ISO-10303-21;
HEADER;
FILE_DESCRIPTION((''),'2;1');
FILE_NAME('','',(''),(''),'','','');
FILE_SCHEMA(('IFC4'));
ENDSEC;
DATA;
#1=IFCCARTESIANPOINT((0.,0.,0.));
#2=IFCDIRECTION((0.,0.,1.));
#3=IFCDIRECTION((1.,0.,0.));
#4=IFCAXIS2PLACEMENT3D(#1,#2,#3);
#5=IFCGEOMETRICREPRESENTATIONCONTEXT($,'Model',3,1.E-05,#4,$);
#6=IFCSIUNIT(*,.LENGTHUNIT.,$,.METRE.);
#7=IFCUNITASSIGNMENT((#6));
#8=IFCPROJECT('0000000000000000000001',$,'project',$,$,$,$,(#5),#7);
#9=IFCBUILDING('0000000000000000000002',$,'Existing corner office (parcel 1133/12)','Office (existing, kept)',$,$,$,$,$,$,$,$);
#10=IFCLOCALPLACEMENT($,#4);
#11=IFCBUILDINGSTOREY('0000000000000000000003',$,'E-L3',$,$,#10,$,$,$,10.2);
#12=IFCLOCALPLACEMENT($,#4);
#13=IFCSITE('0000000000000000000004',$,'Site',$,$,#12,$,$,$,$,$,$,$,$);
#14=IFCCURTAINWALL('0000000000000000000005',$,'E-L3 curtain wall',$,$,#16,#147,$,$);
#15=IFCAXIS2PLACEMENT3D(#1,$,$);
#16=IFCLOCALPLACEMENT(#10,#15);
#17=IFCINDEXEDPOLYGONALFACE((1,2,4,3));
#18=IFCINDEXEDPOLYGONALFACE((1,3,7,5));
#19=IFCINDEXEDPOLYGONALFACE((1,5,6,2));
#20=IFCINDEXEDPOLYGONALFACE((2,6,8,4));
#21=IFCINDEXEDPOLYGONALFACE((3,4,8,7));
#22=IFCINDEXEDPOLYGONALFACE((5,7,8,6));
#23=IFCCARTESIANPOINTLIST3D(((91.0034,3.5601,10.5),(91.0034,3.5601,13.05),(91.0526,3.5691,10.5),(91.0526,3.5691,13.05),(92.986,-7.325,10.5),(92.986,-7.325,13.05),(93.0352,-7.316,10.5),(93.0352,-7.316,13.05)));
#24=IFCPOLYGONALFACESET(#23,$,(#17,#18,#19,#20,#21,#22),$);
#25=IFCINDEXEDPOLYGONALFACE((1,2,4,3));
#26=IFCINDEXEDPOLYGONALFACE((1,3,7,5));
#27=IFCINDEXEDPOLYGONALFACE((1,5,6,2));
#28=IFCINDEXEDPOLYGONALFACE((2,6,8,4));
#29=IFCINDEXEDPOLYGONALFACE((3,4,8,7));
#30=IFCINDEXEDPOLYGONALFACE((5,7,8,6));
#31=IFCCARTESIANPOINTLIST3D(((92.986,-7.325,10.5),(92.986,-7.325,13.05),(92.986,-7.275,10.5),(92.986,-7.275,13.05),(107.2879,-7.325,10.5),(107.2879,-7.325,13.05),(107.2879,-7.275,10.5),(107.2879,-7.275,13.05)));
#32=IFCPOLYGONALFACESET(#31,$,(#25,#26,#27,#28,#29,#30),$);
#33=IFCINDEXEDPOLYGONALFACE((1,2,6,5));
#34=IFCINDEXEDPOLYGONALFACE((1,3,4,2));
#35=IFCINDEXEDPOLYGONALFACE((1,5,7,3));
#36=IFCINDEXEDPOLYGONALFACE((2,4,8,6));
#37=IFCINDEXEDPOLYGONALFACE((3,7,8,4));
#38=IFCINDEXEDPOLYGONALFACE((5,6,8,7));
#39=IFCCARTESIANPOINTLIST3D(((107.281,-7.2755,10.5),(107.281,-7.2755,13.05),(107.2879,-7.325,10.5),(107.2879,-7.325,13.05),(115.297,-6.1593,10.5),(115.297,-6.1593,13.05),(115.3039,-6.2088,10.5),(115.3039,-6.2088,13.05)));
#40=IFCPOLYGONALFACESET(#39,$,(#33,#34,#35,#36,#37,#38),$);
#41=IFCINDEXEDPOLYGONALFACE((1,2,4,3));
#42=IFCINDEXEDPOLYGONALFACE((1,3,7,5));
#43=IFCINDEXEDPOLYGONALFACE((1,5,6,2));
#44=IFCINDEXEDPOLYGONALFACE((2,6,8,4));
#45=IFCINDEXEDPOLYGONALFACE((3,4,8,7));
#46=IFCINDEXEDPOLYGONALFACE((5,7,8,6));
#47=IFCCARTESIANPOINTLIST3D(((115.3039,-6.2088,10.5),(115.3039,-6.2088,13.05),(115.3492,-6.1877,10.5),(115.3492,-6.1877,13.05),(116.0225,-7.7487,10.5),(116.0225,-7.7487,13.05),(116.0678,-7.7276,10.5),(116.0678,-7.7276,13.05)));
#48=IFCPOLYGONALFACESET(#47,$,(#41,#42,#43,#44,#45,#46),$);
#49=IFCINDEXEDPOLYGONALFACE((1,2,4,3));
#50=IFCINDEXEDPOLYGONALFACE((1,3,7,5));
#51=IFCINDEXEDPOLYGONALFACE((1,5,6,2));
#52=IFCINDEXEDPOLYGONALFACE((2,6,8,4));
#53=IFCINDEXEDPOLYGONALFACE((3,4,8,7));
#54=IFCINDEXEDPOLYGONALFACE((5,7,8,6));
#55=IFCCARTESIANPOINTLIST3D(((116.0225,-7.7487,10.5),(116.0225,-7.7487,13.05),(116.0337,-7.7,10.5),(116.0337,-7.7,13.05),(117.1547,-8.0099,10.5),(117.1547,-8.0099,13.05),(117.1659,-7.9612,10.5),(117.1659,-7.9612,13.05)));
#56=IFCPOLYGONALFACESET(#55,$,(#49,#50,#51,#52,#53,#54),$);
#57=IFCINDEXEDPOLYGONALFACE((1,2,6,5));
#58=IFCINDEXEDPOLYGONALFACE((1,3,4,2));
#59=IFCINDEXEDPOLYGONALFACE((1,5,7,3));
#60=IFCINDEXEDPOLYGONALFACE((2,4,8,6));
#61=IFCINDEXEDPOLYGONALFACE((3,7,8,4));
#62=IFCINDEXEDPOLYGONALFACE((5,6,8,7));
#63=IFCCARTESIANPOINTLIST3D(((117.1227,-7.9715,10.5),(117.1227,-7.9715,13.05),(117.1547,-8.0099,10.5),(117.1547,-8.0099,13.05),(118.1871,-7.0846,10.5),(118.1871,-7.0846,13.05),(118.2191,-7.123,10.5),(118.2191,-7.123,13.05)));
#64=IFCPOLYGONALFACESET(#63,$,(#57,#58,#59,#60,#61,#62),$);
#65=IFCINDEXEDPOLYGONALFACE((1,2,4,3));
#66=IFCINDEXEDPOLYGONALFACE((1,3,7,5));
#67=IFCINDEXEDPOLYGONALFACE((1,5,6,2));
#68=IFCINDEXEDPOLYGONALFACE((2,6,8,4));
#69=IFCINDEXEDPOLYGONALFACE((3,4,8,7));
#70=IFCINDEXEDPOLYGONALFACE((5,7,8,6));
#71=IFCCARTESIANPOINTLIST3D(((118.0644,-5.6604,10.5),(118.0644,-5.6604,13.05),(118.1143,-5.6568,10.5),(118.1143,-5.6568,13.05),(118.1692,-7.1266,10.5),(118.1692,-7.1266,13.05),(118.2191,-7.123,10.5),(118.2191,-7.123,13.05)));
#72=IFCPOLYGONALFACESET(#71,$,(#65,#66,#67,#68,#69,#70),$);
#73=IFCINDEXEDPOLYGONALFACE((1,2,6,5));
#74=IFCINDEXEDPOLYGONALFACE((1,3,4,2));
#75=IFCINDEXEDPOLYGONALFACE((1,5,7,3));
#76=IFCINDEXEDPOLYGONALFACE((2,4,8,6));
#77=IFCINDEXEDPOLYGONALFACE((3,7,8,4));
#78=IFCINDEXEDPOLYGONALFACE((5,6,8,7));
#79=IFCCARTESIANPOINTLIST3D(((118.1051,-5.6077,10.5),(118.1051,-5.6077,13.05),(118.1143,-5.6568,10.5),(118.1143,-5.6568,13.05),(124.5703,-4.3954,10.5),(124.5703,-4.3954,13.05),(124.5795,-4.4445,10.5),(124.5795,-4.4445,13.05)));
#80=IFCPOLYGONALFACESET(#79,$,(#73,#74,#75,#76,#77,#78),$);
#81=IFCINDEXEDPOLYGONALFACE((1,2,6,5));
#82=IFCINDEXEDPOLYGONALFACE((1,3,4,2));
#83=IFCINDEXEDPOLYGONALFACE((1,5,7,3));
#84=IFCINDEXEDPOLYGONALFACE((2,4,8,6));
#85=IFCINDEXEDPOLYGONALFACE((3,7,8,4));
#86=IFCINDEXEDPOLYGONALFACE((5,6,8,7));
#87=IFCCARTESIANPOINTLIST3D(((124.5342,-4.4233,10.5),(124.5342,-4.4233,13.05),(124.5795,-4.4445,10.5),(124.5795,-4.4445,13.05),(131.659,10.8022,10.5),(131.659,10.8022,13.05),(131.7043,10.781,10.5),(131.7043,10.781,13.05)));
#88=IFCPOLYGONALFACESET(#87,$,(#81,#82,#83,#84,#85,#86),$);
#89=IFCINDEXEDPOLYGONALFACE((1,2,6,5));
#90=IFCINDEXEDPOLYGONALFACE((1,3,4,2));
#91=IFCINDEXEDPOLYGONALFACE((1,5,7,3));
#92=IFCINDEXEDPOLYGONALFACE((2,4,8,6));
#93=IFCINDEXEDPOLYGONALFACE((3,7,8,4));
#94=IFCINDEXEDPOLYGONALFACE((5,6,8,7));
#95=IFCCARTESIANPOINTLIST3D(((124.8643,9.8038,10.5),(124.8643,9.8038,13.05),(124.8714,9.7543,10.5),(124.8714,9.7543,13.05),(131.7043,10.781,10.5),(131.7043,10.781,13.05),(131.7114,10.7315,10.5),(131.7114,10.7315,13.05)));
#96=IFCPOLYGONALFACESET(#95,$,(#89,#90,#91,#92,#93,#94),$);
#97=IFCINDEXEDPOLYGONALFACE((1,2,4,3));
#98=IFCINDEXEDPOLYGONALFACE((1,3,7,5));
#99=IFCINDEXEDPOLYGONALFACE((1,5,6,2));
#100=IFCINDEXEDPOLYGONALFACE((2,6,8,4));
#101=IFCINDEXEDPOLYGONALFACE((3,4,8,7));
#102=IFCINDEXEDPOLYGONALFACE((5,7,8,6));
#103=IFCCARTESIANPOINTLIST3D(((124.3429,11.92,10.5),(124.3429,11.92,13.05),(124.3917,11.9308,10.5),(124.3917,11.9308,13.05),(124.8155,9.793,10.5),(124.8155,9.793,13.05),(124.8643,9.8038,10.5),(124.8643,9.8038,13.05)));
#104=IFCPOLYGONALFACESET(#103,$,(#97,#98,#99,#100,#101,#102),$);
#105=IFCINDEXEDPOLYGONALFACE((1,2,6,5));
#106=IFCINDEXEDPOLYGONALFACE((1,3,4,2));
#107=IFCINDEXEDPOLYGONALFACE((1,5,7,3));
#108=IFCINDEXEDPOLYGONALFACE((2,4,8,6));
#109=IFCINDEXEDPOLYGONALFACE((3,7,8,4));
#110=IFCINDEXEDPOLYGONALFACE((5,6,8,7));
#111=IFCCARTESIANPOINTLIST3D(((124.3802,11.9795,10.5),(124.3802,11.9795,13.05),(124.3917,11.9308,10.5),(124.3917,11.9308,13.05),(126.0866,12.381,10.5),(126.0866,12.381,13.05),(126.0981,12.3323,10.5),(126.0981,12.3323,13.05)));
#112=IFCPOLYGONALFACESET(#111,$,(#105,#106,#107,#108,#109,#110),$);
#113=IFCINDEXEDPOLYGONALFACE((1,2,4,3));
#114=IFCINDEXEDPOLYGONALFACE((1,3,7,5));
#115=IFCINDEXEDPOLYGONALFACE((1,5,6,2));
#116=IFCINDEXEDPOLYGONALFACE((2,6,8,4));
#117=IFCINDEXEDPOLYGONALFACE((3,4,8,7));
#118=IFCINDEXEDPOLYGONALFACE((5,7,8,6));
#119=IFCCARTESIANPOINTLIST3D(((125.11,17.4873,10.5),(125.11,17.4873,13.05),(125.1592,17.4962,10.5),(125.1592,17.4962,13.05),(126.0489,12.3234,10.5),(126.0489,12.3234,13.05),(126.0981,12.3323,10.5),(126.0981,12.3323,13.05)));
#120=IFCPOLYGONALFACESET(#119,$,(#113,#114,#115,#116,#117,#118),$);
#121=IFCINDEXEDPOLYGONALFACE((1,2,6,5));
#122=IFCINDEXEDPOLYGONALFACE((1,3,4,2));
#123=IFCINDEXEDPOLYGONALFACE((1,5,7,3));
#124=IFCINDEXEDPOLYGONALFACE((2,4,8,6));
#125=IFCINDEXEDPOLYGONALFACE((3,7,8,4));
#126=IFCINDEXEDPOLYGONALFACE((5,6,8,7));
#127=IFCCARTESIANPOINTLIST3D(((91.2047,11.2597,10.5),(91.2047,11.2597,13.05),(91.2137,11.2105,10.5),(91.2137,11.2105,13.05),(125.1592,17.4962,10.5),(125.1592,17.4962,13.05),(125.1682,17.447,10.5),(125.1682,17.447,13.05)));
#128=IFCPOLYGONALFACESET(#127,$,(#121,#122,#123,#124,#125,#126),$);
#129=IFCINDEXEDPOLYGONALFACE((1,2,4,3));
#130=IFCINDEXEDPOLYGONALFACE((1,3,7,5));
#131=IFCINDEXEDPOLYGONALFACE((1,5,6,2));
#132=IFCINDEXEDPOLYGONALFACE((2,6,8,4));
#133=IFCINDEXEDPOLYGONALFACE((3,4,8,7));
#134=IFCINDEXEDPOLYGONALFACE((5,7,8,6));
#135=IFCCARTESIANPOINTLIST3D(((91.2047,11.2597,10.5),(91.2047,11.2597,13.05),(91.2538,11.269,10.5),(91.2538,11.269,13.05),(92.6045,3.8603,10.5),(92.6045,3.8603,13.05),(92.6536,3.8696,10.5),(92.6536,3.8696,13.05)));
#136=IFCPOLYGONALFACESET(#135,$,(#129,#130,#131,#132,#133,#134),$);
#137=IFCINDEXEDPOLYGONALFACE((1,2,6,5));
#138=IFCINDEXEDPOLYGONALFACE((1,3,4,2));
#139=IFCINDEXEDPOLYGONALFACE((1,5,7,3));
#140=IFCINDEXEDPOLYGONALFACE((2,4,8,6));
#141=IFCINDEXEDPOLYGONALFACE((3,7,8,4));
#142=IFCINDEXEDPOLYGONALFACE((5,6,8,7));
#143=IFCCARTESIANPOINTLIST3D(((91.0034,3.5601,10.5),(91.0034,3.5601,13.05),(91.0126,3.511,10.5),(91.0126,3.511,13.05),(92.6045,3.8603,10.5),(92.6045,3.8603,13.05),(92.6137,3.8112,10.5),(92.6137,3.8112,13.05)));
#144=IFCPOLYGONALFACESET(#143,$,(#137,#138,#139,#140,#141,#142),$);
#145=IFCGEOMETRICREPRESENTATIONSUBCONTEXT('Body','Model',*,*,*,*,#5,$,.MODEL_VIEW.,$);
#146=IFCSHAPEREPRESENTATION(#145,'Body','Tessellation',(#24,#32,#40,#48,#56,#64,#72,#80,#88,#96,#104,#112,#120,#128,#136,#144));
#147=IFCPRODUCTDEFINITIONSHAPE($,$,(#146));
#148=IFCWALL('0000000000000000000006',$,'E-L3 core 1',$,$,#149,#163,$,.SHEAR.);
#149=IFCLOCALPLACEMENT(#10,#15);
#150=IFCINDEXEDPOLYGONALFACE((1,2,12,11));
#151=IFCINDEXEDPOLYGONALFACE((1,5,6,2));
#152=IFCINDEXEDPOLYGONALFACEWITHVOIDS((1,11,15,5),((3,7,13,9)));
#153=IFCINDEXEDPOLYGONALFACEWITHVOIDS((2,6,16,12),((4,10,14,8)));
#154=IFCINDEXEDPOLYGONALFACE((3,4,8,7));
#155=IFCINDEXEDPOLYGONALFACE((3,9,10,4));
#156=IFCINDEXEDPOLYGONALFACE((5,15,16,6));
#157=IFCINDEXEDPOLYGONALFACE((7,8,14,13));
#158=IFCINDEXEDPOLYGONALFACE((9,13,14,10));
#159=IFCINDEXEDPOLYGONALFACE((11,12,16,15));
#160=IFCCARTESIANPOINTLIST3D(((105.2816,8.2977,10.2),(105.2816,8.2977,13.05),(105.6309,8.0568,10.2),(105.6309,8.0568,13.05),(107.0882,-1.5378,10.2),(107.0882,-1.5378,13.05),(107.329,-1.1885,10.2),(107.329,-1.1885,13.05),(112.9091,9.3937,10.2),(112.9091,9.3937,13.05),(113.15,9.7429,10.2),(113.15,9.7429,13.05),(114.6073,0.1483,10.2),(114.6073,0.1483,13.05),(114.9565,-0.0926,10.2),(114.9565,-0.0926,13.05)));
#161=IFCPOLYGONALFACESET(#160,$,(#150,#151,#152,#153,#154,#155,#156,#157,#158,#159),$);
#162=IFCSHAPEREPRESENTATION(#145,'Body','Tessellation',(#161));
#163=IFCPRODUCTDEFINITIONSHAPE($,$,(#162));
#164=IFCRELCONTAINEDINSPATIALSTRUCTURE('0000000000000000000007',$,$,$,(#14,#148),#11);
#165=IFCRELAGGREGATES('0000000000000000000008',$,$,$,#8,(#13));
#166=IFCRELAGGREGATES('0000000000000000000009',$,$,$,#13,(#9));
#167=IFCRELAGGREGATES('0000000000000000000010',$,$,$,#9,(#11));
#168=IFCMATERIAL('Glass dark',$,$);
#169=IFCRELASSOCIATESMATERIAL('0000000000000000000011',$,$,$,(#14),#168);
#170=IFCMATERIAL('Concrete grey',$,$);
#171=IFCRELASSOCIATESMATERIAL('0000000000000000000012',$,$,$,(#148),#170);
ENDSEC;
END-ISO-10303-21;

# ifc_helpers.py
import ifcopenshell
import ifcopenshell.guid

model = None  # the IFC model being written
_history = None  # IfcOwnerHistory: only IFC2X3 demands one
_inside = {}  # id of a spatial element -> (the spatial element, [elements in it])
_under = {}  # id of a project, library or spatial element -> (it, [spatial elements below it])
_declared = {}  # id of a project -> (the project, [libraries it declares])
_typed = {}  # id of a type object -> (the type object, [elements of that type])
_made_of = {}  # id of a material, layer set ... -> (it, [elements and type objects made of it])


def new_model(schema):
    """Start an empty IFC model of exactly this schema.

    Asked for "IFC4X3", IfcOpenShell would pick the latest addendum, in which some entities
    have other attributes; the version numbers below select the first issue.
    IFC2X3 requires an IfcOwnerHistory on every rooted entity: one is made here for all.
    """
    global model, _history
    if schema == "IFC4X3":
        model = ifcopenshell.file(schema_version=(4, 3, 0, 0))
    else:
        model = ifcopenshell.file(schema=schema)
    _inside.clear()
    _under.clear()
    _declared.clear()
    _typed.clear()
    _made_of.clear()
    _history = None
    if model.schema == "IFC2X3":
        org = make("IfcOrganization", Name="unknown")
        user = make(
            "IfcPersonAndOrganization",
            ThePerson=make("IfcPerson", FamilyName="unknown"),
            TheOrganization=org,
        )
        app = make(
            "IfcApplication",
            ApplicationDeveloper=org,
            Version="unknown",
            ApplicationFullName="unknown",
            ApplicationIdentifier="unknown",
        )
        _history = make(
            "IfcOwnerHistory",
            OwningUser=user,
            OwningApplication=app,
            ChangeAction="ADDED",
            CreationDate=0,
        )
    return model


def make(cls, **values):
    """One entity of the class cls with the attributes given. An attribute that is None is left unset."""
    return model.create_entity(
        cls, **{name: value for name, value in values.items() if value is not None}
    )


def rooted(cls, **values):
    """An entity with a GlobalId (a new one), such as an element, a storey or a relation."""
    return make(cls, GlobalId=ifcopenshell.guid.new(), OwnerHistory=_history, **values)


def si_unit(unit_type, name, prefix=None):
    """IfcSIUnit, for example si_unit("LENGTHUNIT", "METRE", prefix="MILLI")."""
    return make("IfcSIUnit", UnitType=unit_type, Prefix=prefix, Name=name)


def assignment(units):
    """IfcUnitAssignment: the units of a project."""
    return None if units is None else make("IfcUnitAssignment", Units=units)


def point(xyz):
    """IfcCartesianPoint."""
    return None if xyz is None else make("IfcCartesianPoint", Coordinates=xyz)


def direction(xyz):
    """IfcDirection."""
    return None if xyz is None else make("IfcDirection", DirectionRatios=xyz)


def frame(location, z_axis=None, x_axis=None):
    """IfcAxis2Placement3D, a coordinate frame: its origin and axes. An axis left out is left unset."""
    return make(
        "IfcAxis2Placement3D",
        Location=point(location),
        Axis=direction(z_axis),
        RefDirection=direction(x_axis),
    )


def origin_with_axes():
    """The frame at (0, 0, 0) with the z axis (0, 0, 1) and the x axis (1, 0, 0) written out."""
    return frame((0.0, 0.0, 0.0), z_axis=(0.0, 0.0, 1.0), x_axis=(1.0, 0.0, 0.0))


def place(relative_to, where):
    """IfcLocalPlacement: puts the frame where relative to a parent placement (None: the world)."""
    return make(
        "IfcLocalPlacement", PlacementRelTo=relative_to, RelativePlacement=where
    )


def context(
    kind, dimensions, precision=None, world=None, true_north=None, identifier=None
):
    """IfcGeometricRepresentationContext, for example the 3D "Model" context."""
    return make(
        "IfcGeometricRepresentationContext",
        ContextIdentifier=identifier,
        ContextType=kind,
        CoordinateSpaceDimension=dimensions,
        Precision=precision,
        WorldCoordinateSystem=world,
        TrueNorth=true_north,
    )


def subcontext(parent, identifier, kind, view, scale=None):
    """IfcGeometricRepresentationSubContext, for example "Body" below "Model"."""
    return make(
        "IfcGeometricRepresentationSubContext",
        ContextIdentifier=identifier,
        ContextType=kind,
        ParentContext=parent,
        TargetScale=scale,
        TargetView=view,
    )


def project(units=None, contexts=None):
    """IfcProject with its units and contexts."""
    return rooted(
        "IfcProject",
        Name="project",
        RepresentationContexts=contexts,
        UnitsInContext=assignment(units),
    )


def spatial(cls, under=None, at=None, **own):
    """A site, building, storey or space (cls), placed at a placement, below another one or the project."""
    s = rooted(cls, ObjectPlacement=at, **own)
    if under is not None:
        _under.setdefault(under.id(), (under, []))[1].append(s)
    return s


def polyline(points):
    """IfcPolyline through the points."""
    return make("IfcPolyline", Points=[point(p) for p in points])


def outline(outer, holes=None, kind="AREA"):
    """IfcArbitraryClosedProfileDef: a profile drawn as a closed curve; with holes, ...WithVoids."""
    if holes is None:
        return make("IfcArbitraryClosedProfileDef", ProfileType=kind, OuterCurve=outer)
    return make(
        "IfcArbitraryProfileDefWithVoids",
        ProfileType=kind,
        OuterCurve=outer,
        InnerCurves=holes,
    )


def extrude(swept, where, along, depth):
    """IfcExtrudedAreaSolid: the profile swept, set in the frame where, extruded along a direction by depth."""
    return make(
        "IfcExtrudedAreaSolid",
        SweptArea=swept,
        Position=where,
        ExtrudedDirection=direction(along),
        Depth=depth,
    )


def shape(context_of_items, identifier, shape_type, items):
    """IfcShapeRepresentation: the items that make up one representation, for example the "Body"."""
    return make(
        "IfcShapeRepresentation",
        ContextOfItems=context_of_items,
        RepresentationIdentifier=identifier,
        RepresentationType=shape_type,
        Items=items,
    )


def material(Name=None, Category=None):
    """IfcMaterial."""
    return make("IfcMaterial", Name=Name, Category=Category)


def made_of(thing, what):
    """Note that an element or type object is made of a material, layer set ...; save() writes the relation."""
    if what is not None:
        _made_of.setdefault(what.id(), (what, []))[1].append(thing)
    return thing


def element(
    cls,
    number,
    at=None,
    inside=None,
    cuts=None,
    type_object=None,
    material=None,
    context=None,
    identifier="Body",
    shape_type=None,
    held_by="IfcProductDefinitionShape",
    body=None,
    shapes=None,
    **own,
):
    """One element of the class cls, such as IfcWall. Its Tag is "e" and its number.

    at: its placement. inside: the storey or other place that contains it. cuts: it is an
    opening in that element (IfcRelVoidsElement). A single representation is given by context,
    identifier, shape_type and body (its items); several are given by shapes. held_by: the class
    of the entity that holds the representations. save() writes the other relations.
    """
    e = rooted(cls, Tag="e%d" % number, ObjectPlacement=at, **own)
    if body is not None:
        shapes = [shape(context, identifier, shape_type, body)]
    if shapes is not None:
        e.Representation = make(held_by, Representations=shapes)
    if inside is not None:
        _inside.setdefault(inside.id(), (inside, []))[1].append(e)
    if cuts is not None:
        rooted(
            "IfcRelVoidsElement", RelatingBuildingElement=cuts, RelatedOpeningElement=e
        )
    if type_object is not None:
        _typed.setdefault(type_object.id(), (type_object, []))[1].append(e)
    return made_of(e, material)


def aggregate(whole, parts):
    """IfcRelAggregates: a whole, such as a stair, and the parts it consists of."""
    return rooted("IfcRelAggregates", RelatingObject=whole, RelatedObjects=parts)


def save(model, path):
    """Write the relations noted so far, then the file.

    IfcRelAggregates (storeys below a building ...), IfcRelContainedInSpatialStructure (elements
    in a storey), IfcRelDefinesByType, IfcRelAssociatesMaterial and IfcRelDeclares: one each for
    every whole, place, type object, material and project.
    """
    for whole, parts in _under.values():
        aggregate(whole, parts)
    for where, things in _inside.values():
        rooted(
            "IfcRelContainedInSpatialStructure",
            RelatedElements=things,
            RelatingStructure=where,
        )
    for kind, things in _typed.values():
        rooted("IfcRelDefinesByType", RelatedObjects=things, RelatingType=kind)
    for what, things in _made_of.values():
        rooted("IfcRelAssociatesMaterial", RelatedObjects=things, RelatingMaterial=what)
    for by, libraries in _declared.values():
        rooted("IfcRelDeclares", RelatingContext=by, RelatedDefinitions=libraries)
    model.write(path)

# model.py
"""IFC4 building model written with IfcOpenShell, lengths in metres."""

from ifc_helpers import new_model, si_unit, frame, origin_with_axes, place, context, subcontext, project, spatial, polyline, outline, extrude, material, element, save


model = new_model("IFC4")

# Units and contexts
model_context = context("Model", 3, precision=1e-05, world=origin_with_axes())
body_context = subcontext(model_context, "Body", "Model", "MODEL_VIEW")
ifc_project = project(units=[si_unit("LENGTHUNIT", "METRE")], contexts=[model_context])

# Site, building, storey
site_placement = place(None, origin_with_axes())
site = spatial("IfcSite", under=ifc_project, at=site_placement, Name="Site")
building = spatial("IfcBuilding", under=site, Name="Existing corner office (parcel 1133/12)", Description="Office (existing, kept)")
storey_placement = place(None, origin_with_axes())
storey = spatial("IfcBuildingStorey", under=building, at=storey_placement, Name="E-L3", Elevation=10.2)

# Shared definitions
ifc_material_1 = material(Name="Concrete grey")

# Curtain wall
ifc_material_2 = material(Name="Glass dark")
curtain_wall_placement = place(storey_placement, origin_with_axes())
element("IfcCurtainWall", 1, at=curtain_wall_placement, inside=storey, material=ifc_material_2, Name="E-L3 curtain wall", context=body_context, shape_type="SweptSolid", body=[
    extrude(outline(polyline([(91.0034, 3.5601), (92.986, -7.325), (93.0352, -7.316), (91.0526, 3.5691), (91.0034, 3.5601)])), frame((0.0, 0.0, 10.5), z_axis=(0.0, 0.0, 1.0), x_axis=(1.0, 0.0, 0.0)), (0.0, 0.0, 1.0), 2.55),
    extrude(outline(polyline([(92.986, -7.325), (107.2879, -7.325), (107.2879, -7.275), (92.986, -7.275), (92.986, -7.325)])), frame((0.0, 0.0, 10.5), z_axis=(0.0, 0.0, 1.0), x_axis=(1.0, 0.0, 0.0)), (0.0, 0.0, 1.0), 2.55),
    extrude(outline(polyline([(107.2879, -7.325), (115.3039, -6.2088), (115.297, -6.1593), (107.281, -7.2755), (107.2879, -7.325)])), frame((0.0, 0.0, 10.5), z_axis=(0.0, 0.0, 1.0), x_axis=(1.0, 0.0, 0.0)), (0.0, 0.0, 1.0), 2.55),
    extrude(outline(polyline([(115.3039, -6.2088), (116.0225, -7.7487), (116.0678, -7.7276), (115.3492, -6.1877), (115.3039, -6.2088)])), frame((0.0, 0.0, 10.5), z_axis=(0.0, 0.0, 1.0), x_axis=(1.0, 0.0, 0.0)), (0.0, 0.0, 1.0), 2.55),
    extrude(outline(polyline([(116.0225, -7.7487), (117.1547, -8.0099), (117.1659, -7.9612), (116.0337, -7.7), (116.0225, -7.7487)])), frame((0.0, 0.0, 10.5), z_axis=(0.0, 0.0, 1.0), x_axis=(1.0, 0.0, 0.0)), (0.0, 0.0, 1.0), 2.55),
    extrude(outline(polyline([(117.1547, -8.0099), (118.2191, -7.123), (118.1871, -7.0846), (117.1227, -7.9715), (117.1547, -8.0099)])), frame((0.0, 0.0, 10.5), z_axis=(0.0, 0.0, 1.0), x_axis=(1.0, 0.0, 0.0)), (0.0, 0.0, 1.0), 2.55),
    extrude(outline(polyline([(118.2191, -7.123), (118.1143, -5.6568), (118.0644, -5.6604), (118.1692, -7.1266), (118.2191, -7.123)])), frame((0.0, 0.0, 10.5), z_axis=(0.0, 0.0, 1.0), x_axis=(1.0, 0.0, 0.0)), (0.0, 0.0, 1.0), 2.55),
    extrude(outline(polyline([(118.1143, -5.6568), (124.5795, -4.4445), (124.5703, -4.3954), (118.1051, -5.6077), (118.1143, -5.6568)])), frame((0.0, 0.0, 10.5), z_axis=(0.0, 0.0, 1.0), x_axis=(1.0, 0.0, 0.0)), (0.0, 0.0, 1.0), 2.55),
    extrude(outline(polyline([(124.5795, -4.4445), (131.7043, 10.781), (131.659, 10.8022), (124.5342, -4.4233), (124.5795, -4.4445)])), frame((0.0, 0.0, 10.5), z_axis=(0.0, 0.0, 1.0), x_axis=(1.0, 0.0, 0.0)), (0.0, 0.0, 1.0), 2.55),
    extrude(outline(polyline([(131.7043, 10.781), (124.8643, 9.8038), (124.8714, 9.7543), (131.7114, 10.7315), (131.7043, 10.781)])), frame((0.0, 0.0, 10.5), z_axis=(0.0, 0.0, 1.0), x_axis=(1.0, 0.0, 0.0)), (0.0, 0.0, 1.0), 2.55),
    extrude(outline(polyline([(124.8643, 9.8038), (124.3917, 11.9308), (124.3429, 11.92), (124.8155, 9.793), (124.8643, 9.8038)])), frame((0.0, 0.0, 10.5), z_axis=(0.0, 0.0, 1.0), x_axis=(1.0, 0.0, 0.0)), (0.0, 0.0, 1.0), 2.55),
    extrude(outline(polyline([(124.3917, 11.9308), (126.0981, 12.3323), (126.0866, 12.381), (124.3802, 11.9795), (124.3917, 11.9308)])), frame((0.0, 0.0, 10.5), z_axis=(0.0, 0.0, 1.0), x_axis=(1.0, 0.0, 0.0)), (0.0, 0.0, 1.0), 2.55),
    extrude(outline(polyline([(126.0981, 12.3323), (125.1592, 17.4962), (125.11, 17.4873), (126.0489, 12.3234), (126.0981, 12.3323)])), frame((0.0, 0.0, 10.5), z_axis=(0.0, 0.0, 1.0), x_axis=(1.0, 0.0, 0.0)), (0.0, 0.0, 1.0), 2.55),
    extrude(outline(polyline([(125.1592, 17.4962), (91.2047, 11.2597), (91.2137, 11.2105), (125.1682, 17.447), (125.1592, 17.4962)])), frame((0.0, 0.0, 10.5), z_axis=(0.0, 0.0, 1.0), x_axis=(1.0, 0.0, 0.0)), (0.0, 0.0, 1.0), 2.55),
    extrude(outline(polyline([(91.2047, 11.2597), (92.6045, 3.8603), (92.6536, 3.8696), (91.2538, 11.269), (91.2047, 11.2597)])), frame((0.0, 0.0, 10.5), z_axis=(0.0, 0.0, 1.0), x_axis=(1.0, 0.0, 0.0)), (0.0, 0.0, 1.0), 2.55),
    extrude(outline(polyline([(92.6045, 3.8603), (91.0034, 3.5601), (91.0126, 3.511), (92.6137, 3.8112), (92.6045, 3.8603)])), frame((0.0, 0.0, 10.5), z_axis=(0.0, 0.0, 1.0), x_axis=(1.0, 0.0, 0.0)), (0.0, 0.0, 1.0), 2.55),
])

# Wall
wall_placement = place(storey_placement, origin_with_axes())
element("IfcWall", 2, at=wall_placement, inside=storey, material=ifc_material_1, Name="E-L3 core 1", PredefinedType="SHEAR", context=body_context, shape_type="SweptSolid", body=[
    extrude(outline(polyline([(113.15, 9.7429), (105.2816, 8.2977), (107.0882, -1.5378), (114.9565, -0.0926), (113.15, 9.7429)]), holes=[polyline([(112.9091, 9.3937), (105.6309, 8.0568), (107.329, -1.1885), (114.6073, 0.1483), (112.9091, 9.3937)])]), frame((0.0, 0.0, 10.2), z_axis=(0.0, 0.0, 1.0), x_axis=(1.0, 0.0, 0.0)), (0.0, 0.0, 1.0), 2.85),
])

save(model, "model.ifc")
